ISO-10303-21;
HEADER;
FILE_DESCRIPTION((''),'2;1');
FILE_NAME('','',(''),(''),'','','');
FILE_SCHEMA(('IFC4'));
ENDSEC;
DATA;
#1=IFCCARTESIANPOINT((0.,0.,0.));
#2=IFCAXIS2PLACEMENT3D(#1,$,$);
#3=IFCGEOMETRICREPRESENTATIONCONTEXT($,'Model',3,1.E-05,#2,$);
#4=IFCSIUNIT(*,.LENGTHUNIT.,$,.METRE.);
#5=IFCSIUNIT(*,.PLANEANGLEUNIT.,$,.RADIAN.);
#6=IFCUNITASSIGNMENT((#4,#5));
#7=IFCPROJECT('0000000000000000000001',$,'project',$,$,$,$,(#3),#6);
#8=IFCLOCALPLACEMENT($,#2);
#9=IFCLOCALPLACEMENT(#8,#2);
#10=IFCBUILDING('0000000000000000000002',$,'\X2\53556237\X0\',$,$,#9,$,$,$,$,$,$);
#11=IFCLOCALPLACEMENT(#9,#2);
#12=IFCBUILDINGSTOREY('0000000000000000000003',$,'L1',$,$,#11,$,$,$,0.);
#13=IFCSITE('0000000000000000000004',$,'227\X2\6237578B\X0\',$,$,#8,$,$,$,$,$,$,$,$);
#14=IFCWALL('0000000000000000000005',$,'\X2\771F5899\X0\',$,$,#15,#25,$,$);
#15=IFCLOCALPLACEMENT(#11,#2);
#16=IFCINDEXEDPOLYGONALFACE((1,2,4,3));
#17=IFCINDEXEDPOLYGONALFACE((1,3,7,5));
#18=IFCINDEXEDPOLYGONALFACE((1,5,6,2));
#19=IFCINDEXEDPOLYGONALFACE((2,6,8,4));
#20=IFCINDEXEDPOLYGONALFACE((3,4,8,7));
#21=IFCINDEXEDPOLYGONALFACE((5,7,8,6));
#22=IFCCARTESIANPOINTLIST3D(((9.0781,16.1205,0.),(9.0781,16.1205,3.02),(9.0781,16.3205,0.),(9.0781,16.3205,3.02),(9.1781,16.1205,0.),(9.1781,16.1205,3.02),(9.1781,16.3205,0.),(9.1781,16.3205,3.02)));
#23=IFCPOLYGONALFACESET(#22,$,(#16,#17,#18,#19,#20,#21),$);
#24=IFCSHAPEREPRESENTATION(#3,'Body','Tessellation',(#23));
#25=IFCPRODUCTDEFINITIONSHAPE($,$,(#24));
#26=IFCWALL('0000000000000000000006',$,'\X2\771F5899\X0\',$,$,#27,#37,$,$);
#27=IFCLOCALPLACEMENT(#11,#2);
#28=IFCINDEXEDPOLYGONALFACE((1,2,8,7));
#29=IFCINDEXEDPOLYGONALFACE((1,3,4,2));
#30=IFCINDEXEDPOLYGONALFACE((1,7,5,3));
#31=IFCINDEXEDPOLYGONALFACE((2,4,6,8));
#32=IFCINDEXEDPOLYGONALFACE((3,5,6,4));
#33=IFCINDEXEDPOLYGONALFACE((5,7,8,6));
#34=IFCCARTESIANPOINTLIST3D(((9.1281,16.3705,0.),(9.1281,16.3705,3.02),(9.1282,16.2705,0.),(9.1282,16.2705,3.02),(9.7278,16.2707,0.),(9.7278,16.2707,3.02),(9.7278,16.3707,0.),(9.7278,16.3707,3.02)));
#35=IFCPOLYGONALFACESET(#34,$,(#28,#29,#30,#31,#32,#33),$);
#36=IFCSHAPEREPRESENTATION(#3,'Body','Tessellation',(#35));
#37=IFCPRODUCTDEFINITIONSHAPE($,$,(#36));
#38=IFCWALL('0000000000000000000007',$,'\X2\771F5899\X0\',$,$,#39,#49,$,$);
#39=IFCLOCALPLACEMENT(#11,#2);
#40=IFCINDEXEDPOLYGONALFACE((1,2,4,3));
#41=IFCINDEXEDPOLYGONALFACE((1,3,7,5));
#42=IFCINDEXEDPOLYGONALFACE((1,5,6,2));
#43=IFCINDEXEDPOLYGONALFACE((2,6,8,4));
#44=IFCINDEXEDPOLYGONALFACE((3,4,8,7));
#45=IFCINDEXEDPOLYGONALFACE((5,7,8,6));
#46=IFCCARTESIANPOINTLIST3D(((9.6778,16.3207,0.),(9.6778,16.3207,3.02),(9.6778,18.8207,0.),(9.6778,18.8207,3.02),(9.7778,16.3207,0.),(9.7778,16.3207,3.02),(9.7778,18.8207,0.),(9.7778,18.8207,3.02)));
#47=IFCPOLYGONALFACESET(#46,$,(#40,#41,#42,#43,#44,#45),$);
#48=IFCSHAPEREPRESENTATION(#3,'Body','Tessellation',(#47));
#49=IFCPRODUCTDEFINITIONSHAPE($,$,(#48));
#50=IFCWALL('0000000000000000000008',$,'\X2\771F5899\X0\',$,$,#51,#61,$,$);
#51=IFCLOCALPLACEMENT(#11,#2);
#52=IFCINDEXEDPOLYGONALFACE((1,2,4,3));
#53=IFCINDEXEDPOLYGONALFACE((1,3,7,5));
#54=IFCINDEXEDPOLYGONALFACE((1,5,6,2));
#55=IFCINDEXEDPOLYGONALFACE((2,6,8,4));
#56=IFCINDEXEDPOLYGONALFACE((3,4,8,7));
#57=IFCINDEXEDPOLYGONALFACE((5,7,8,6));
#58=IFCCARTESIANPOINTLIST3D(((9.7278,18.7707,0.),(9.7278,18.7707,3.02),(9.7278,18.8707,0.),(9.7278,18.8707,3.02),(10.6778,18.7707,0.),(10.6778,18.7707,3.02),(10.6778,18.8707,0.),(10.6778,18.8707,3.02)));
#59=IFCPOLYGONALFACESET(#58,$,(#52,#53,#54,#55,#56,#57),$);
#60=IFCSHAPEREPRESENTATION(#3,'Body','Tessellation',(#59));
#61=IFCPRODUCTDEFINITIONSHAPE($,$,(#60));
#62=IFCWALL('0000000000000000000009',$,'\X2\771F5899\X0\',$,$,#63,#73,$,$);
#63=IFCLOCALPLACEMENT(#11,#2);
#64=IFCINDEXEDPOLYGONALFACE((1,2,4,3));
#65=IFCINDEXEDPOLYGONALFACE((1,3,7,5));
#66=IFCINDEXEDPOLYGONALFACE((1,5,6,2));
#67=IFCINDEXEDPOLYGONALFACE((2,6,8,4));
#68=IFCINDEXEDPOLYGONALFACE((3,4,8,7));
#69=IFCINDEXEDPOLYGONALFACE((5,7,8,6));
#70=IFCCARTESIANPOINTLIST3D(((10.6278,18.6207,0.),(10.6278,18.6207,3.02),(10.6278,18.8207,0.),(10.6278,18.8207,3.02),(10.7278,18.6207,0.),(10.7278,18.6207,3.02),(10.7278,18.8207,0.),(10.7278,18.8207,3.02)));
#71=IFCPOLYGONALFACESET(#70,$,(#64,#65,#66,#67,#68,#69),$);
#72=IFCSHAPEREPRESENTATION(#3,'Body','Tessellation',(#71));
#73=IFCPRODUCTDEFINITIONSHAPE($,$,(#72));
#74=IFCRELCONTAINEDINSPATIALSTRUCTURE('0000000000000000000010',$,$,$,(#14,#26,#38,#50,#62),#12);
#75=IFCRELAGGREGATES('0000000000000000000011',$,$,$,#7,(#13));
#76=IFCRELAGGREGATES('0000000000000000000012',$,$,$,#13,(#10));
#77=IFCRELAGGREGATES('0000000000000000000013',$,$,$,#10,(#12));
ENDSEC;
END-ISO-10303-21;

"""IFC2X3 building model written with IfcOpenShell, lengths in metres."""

from ifc_helpers import new_model, si_unit, origin, place, context, project, spatial, polyline, outline, extrude, element, save


model = new_model("IFC2X3")

# Units and contexts
model_context = context("Model", 3, precision=1e-05, world=origin())
ifc_project = project(units=[si_unit("LENGTHUNIT", "METRE"), si_unit("PLANEANGLEUNIT", "RADIAN")], contexts=[model_context])

# Site, building, storey
site_placement = place(None, origin())
site = spatial("IfcSite", under=ifc_project, at=site_placement, Name="227户型")
building_placement = place(site_placement, origin())
building = spatial("IfcBuilding", under=site, at=building_placement, Name="单户")
storey_placement = place(building_placement, origin())
storey = spatial("IfcBuildingStorey", under=building, at=storey_placement, Name="L1", Elevation=0.0)

# Walls
wall_1_placement = place(storey_placement, origin())
element("IfcWall", 1, at=wall_1_placement, inside=storey, Name="真墙", context=model_context, shape_type="SweptSolid", body=[
    extrude(outline(polyline([(9.0781, 16.1205), (9.0781, 16.3205), (9.1781, 16.3205), (9.1781, 16.1205), (9.0781, 16.1205)])), origin(), (0.0, 0.0, 1.0), 3.02),
])
wall_2_placement = place(storey_placement, origin())
element("IfcWall", 2, at=wall_2_placement, inside=storey, Name="真墙", context=model_context, shape_type="SweptSolid", body=[
    extrude(outline(polyline([(9.1281, 16.3705), (9.7278, 16.3707), (9.7278, 16.2707), (9.1282, 16.2705), (9.1281, 16.3705)])), origin(), (0.0, 0.0, 1.0), 3.02),
])
wall_3_placement = place(storey_placement, origin())
element("IfcWall", 3, at=wall_3_placement, inside=storey, Name="真墙", context=model_context, shape_type="SweptSolid", body=[
    extrude(outline(polyline([(9.6778, 16.3207), (9.6778, 18.8207), (9.7778, 18.8207), (9.7778, 16.3207), (9.6778, 16.3207)])), origin(), (0.0, 0.0, 1.0), 3.02),
])
wall_4_placement = place(storey_placement, origin())
element("IfcWall", 4, at=wall_4_placement, inside=storey, Name="真墙", context=model_context, shape_type="SweptSolid", body=[
    extrude(outline(polyline([(9.7278, 18.8707), (10.6778, 18.8707), (10.6778, 18.7707), (9.7278, 18.7707), (9.7278, 18.8707)])), origin(), (0.0, 0.0, 1.0), 3.02),
])
wall_5_placement = place(storey_placement, origin())
element("IfcWall", 5, at=wall_5_placement, inside=storey, Name="真墙", context=model_context, shape_type="SweptSolid", body=[
    extrude(outline(polyline([(10.7278, 18.8207), (10.7278, 18.6207), (10.6278, 18.6207), (10.6278, 18.8207), (10.7278, 18.8207)])), origin(), (0.0, 0.0, 1.0), 3.02),
])

save(model, "model.ifc")
